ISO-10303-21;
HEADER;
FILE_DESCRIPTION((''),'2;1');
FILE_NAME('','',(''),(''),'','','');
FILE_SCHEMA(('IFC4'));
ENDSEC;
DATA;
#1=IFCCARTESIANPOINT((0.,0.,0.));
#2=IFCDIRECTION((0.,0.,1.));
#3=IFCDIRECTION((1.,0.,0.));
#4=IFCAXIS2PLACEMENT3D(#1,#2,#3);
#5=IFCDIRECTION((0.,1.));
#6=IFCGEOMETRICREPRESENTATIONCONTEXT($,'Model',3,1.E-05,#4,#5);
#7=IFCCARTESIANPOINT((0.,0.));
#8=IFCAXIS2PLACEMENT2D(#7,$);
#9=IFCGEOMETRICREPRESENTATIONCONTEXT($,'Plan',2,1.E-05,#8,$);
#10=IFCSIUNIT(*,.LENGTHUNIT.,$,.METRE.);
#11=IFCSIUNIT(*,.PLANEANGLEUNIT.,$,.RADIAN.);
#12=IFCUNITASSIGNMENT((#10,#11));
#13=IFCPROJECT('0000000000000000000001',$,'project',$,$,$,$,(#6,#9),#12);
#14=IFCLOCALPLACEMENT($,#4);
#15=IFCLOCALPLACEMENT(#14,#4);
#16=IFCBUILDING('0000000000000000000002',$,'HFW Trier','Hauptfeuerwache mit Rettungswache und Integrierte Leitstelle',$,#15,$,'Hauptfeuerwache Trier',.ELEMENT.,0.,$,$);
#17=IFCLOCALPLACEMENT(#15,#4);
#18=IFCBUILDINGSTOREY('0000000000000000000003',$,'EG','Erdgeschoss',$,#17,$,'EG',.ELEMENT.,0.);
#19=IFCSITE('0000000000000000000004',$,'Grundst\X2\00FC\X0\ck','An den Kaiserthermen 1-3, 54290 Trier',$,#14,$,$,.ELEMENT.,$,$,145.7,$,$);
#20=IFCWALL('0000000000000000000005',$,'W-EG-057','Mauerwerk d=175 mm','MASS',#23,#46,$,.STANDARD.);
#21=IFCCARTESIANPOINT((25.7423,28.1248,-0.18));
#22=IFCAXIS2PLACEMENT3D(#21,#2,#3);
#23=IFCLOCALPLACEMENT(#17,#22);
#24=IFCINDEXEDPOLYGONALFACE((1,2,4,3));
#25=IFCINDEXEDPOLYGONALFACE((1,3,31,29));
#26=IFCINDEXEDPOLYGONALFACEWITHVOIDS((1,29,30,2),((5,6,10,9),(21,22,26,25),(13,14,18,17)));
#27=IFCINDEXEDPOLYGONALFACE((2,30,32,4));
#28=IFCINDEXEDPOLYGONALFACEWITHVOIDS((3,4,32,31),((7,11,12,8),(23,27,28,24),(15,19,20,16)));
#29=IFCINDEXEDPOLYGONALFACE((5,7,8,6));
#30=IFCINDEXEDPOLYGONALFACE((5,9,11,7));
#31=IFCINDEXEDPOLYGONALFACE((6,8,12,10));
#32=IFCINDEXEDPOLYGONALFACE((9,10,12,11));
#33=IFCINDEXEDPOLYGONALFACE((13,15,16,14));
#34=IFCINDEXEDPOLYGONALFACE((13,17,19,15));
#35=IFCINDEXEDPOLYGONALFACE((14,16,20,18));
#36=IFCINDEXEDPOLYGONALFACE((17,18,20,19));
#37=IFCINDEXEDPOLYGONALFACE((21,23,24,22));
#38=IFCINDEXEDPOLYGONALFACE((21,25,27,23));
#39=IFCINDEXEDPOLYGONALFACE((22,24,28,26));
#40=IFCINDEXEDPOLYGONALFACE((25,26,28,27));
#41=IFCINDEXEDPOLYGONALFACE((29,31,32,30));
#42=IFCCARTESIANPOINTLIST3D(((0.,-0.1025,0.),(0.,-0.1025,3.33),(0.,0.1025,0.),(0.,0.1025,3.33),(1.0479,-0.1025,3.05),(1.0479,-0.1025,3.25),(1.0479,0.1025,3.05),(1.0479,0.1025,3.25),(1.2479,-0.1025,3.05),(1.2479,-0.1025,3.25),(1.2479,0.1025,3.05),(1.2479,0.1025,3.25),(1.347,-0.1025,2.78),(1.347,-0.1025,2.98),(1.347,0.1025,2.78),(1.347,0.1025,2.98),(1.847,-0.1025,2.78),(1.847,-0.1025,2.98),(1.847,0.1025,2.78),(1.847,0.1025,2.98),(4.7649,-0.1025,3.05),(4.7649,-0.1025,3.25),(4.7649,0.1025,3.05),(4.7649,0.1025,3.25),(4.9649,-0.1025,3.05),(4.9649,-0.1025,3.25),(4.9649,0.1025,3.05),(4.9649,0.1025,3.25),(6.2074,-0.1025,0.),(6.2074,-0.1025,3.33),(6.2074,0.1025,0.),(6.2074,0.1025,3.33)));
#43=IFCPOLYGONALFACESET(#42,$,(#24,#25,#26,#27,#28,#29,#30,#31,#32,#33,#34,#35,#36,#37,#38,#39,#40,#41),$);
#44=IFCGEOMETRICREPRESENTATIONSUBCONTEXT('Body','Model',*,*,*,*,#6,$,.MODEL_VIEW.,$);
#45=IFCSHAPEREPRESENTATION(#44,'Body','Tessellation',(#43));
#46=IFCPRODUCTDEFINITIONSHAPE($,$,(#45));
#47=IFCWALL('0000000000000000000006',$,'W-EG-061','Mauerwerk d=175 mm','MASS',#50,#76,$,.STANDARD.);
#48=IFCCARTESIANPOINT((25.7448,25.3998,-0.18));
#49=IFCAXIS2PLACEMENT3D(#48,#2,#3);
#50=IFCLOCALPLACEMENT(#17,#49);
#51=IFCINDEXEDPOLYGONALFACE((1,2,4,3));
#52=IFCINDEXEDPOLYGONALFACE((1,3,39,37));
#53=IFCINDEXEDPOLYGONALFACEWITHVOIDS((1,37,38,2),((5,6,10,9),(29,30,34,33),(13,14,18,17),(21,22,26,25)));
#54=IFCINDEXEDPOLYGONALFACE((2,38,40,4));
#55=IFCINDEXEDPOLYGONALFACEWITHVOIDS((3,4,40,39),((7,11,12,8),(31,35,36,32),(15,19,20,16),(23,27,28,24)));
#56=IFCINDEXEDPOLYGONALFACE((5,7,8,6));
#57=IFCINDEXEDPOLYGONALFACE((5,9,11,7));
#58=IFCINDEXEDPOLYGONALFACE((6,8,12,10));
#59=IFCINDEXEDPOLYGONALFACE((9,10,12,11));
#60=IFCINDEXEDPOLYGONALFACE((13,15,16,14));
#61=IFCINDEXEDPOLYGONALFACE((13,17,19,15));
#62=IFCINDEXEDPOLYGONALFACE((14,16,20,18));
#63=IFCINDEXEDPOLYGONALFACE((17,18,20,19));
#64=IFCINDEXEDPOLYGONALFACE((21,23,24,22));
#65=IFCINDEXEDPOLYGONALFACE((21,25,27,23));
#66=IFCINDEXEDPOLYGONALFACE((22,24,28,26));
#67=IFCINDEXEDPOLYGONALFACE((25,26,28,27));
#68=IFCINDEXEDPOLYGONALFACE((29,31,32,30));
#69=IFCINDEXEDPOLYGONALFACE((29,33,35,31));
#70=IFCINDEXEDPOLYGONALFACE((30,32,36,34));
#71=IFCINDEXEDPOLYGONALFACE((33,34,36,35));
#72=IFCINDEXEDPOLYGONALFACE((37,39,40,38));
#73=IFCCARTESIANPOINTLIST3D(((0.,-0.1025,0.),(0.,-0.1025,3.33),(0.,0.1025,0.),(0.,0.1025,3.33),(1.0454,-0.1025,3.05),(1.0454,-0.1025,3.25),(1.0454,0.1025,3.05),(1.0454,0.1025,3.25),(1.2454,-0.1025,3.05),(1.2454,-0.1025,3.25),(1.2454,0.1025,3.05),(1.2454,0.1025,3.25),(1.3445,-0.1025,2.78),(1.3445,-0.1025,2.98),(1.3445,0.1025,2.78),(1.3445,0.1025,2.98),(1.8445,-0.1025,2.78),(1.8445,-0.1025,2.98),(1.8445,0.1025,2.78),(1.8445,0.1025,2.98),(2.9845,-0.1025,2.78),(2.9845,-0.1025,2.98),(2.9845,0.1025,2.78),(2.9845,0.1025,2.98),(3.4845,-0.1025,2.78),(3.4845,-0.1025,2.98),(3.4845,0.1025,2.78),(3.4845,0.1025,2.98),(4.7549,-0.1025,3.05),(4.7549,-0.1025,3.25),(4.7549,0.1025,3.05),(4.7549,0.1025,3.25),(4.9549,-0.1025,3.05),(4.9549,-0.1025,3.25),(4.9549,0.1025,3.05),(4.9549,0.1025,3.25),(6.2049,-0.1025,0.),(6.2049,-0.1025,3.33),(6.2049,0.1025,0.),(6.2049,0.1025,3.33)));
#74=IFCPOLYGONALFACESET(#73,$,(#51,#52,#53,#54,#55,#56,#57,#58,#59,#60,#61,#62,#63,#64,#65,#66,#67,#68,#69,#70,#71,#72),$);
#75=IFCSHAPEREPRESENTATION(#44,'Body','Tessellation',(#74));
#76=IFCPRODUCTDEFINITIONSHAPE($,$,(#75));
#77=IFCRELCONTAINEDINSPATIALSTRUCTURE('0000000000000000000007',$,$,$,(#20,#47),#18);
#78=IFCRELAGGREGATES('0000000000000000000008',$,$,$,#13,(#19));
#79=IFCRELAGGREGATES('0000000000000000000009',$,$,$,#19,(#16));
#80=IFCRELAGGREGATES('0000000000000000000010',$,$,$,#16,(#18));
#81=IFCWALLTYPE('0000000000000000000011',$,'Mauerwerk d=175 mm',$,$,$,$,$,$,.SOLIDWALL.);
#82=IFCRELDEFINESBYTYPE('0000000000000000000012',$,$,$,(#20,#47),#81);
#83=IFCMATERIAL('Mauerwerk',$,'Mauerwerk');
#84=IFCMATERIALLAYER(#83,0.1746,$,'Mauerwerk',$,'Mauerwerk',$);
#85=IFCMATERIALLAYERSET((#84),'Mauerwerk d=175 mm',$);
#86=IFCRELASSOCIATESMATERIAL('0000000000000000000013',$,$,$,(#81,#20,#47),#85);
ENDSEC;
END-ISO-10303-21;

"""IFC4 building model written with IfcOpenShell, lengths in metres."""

from ifc_helpers import new_model, si_unit, direction, frame, frame_2d, origin_with_axes, origin_2d, place, context, subcontext, project, spatial, rectangle, extrude, material, layer, layer_set, layer_usage, type_object, element, save


model = new_model("IFC4")

# Units and contexts
model_context = context("Model", 3, precision=1e-05, world=origin_with_axes(), true_north=direction((0.0, 1.0)))
plan_context = context("Plan", 2, precision=1e-05, world=origin_2d())
body_context = subcontext(model_context, "Body", "Model", "MODEL_VIEW")
ifc_project = project(units=[si_unit("LENGTHUNIT", "METRE"), si_unit("PLANEANGLEUNIT", "RADIAN")], contexts=[model_context, plan_context])

# Site, building, storey
site_placement = place(None, origin_with_axes())
site = spatial("IfcSite", under=ifc_project, at=site_placement, Name="Grundstück", Description="An den Kaiserthermen 1-3, 54290 Trier", CompositionType="ELEMENT", RefElevation=145.7)
building_placement = place(site_placement, origin_with_axes())
building = spatial("IfcBuilding", under=site, at=building_placement, Name="HFW Trier", Description="Hauptfeuerwache mit Rettungswache und Integrierte Leitstelle", LongName="Hauptfeuerwache Trier", CompositionType="ELEMENT", ElevationOfRefHeight=0.0)
storey_placement = place(building_placement, origin_with_axes())
storey = spatial("IfcBuildingStorey", under=building, at=storey_placement, Name="EG", Description="Erdgeschoss", LongName="EG", CompositionType="ELEMENT", Elevation=0.0)

# Walls, openings
ifc_material_1 = material(Name="Mauerwerk", Category="Mauerwerk")
ifc_layer_1 = layer(ifc_material_1, 0.1746, Name="Mauerwerk", Category="Mauerwerk")
ifc_layer_set_1 = layer_set([ifc_layer_1], Name="Mauerwerk d=175 mm")
ifc_layer_usage_1 = layer_usage(ifc_layer_set_1, "AXIS2", "POSITIVE", -0.1025)
wall_type_1 = type_object("IfcWallType", Name="Mauerwerk d=175 mm", PredefinedType="SOLIDWALL", material=ifc_layer_set_1)
wall_1_placement = place(storey_placement, frame((25.7423, 28.1248, -0.18), z_axis=(0.0, 0.0, 1.0), x_axis=(1.0, 0.0, 0.0)))
wall_1 = element("IfcWall", 1, at=wall_1_placement, inside=storey, type_object=wall_type_1, material=ifc_layer_usage_1, Name="W-EG-057", Description="Mauerwerk d=175 mm", ObjectType="MASS", PredefinedType="STANDARD", context=body_context, shape_type="SweptSolid", body=[
    extrude(rectangle(XDim=6.2074, YDim=0.205, at=frame_2d((3.1037, 0.0))), origin_with_axes(), (0.0, 0.0, 1.0), 3.33),
])
opening_1_placement = place(wall_1_placement, origin_with_axes())
element("IfcOpeningElement", 2, at=opening_1_placement, cuts=wall_1, ObjectType="Wanddurchbruch", PredefinedType="OPENING", context=body_context, shape_type="SweptSolid", body=[
    extrude(rectangle(XDim=0.5, YDim=0.305, at=frame_2d((1.597, 0.0))), frame((0.0, 0.0, 2.78), z_axis=(0.0, 0.0, 1.0), x_axis=(1.0, 0.0, 0.0)), (0.0, 0.0, 1.0), 0.2),
])
opening_2_placement = place(wall_1_placement, origin_with_axes())
element("IfcOpeningElement", 3, at=opening_2_placement, cuts=wall_1, ObjectType="Wanddurchbruch", PredefinedType="OPENING", context=body_context, shape_type="SweptSolid", body=[
    extrude(rectangle(XDim=0.2, YDim=0.305, at=frame_2d((1.1479, 0.0))), frame((0.0, 0.0, 3.05), z_axis=(0.0, 0.0, 1.0), x_axis=(1.0, 0.0, 0.0)), (0.0, 0.0, 1.0), 0.2),
])
opening_3_placement = place(wall_1_placement, origin_with_axes())
element("IfcOpeningElement", 4, at=opening_3_placement, cuts=wall_1, ObjectType="Wanddurchbruch", PredefinedType="OPENING", context=body_context, shape_type="SweptSolid", body=[
    extrude(rectangle(XDim=0.2, YDim=0.305, at=frame_2d((4.8649, 0.0))), frame((0.0, 0.0, 3.05), z_axis=(0.0, 0.0, 1.0), x_axis=(1.0, 0.0, 0.0)), (0.0, 0.0, 1.0), 0.2),
])
ifc_layer_usage_2 = layer_usage(ifc_layer_set_1, "AXIS2", "POSITIVE", -0.1025)
wall_2_placement = place(storey_placement, frame((25.7448, 25.3998, -0.18), z_axis=(0.0, 0.0, 1.0), x_axis=(1.0, 0.0, 0.0)))
wall_2 = element("IfcWall", 5, at=wall_2_placement, inside=storey, type_object=wall_type_1, material=ifc_layer_usage_2, Name="W-EG-061", Description="Mauerwerk d=175 mm", ObjectType="MASS", PredefinedType="STANDARD", context=body_context, shape_type="SweptSolid", body=[
    extrude(rectangle(XDim=6.2049, YDim=0.205, at=frame_2d((3.1024, 0.0))), origin_with_axes(), (0.0, 0.0, 1.0), 3.33),
])
opening_4_placement = place(wall_2_placement, origin_with_axes())
element("IfcOpeningElement", 6, at=opening_4_placement, cuts=wall_2, ObjectType="Wanddurchbruch", PredefinedType="OPENING", context=body_context, shape_type="SweptSolid", body=[
    extrude(rectangle(XDim=0.5, YDim=0.305, at=frame_2d((1.5945, 0.0))), frame((0.0, 0.0, 2.78), z_axis=(0.0, 0.0, 1.0), x_axis=(1.0, 0.0, 0.0)), (0.0, 0.0, 1.0), 0.2),
])
opening_5_placement = place(wall_2_placement, origin_with_axes())
element("IfcOpeningElement", 7, at=opening_5_placement, cuts=wall_2, ObjectType="Wanddurchbruch", PredefinedType="OPENING", context=body_context, shape_type="SweptSolid", body=[
    extrude(rectangle(XDim=0.2, YDim=0.305, at=frame_2d((1.1454, 0.0))), frame((0.0, 0.0, 3.05), z_axis=(0.0, 0.0, 1.0), x_axis=(1.0, 0.0, 0.0)), (0.0, 0.0, 1.0), 0.2),
])
opening_6_placement = place(wall_2_placement, origin_with_axes())
element("IfcOpeningElement", 8, at=opening_6_placement, cuts=wall_2, ObjectType="Wanddurchbruch", PredefinedType="OPENING", context=body_context, shape_type="SweptSolid", body=[
    extrude(rectangle(XDim=0.5, YDim=0.305, at=frame_2d((3.2345, 0.0))), frame((0.0, 0.0, 2.78), z_axis=(0.0, 0.0, 1.0), x_axis=(1.0, 0.0, 0.0)), (0.0, 0.0, 1.0), 0.2),
])
opening_7_placement = place(wall_2_placement, origin_with_axes())
element("IfcOpeningElement", 9, at=opening_7_placement, cuts=wall_2, ObjectType="Wanddurchbruch", PredefinedType="OPENING", context=body_context, shape_type="SweptSolid", body=[
    extrude(rectangle(XDim=0.2, YDim=0.305, at=frame_2d((4.8549, 0.0))), frame((0.0, 0.0, 3.05), z_axis=(0.0, 0.0, 1.0), x_axis=(1.0, 0.0, 0.0)), (0.0, 0.0, 1.0), 0.2),
])

save(model, "model.ifc")
